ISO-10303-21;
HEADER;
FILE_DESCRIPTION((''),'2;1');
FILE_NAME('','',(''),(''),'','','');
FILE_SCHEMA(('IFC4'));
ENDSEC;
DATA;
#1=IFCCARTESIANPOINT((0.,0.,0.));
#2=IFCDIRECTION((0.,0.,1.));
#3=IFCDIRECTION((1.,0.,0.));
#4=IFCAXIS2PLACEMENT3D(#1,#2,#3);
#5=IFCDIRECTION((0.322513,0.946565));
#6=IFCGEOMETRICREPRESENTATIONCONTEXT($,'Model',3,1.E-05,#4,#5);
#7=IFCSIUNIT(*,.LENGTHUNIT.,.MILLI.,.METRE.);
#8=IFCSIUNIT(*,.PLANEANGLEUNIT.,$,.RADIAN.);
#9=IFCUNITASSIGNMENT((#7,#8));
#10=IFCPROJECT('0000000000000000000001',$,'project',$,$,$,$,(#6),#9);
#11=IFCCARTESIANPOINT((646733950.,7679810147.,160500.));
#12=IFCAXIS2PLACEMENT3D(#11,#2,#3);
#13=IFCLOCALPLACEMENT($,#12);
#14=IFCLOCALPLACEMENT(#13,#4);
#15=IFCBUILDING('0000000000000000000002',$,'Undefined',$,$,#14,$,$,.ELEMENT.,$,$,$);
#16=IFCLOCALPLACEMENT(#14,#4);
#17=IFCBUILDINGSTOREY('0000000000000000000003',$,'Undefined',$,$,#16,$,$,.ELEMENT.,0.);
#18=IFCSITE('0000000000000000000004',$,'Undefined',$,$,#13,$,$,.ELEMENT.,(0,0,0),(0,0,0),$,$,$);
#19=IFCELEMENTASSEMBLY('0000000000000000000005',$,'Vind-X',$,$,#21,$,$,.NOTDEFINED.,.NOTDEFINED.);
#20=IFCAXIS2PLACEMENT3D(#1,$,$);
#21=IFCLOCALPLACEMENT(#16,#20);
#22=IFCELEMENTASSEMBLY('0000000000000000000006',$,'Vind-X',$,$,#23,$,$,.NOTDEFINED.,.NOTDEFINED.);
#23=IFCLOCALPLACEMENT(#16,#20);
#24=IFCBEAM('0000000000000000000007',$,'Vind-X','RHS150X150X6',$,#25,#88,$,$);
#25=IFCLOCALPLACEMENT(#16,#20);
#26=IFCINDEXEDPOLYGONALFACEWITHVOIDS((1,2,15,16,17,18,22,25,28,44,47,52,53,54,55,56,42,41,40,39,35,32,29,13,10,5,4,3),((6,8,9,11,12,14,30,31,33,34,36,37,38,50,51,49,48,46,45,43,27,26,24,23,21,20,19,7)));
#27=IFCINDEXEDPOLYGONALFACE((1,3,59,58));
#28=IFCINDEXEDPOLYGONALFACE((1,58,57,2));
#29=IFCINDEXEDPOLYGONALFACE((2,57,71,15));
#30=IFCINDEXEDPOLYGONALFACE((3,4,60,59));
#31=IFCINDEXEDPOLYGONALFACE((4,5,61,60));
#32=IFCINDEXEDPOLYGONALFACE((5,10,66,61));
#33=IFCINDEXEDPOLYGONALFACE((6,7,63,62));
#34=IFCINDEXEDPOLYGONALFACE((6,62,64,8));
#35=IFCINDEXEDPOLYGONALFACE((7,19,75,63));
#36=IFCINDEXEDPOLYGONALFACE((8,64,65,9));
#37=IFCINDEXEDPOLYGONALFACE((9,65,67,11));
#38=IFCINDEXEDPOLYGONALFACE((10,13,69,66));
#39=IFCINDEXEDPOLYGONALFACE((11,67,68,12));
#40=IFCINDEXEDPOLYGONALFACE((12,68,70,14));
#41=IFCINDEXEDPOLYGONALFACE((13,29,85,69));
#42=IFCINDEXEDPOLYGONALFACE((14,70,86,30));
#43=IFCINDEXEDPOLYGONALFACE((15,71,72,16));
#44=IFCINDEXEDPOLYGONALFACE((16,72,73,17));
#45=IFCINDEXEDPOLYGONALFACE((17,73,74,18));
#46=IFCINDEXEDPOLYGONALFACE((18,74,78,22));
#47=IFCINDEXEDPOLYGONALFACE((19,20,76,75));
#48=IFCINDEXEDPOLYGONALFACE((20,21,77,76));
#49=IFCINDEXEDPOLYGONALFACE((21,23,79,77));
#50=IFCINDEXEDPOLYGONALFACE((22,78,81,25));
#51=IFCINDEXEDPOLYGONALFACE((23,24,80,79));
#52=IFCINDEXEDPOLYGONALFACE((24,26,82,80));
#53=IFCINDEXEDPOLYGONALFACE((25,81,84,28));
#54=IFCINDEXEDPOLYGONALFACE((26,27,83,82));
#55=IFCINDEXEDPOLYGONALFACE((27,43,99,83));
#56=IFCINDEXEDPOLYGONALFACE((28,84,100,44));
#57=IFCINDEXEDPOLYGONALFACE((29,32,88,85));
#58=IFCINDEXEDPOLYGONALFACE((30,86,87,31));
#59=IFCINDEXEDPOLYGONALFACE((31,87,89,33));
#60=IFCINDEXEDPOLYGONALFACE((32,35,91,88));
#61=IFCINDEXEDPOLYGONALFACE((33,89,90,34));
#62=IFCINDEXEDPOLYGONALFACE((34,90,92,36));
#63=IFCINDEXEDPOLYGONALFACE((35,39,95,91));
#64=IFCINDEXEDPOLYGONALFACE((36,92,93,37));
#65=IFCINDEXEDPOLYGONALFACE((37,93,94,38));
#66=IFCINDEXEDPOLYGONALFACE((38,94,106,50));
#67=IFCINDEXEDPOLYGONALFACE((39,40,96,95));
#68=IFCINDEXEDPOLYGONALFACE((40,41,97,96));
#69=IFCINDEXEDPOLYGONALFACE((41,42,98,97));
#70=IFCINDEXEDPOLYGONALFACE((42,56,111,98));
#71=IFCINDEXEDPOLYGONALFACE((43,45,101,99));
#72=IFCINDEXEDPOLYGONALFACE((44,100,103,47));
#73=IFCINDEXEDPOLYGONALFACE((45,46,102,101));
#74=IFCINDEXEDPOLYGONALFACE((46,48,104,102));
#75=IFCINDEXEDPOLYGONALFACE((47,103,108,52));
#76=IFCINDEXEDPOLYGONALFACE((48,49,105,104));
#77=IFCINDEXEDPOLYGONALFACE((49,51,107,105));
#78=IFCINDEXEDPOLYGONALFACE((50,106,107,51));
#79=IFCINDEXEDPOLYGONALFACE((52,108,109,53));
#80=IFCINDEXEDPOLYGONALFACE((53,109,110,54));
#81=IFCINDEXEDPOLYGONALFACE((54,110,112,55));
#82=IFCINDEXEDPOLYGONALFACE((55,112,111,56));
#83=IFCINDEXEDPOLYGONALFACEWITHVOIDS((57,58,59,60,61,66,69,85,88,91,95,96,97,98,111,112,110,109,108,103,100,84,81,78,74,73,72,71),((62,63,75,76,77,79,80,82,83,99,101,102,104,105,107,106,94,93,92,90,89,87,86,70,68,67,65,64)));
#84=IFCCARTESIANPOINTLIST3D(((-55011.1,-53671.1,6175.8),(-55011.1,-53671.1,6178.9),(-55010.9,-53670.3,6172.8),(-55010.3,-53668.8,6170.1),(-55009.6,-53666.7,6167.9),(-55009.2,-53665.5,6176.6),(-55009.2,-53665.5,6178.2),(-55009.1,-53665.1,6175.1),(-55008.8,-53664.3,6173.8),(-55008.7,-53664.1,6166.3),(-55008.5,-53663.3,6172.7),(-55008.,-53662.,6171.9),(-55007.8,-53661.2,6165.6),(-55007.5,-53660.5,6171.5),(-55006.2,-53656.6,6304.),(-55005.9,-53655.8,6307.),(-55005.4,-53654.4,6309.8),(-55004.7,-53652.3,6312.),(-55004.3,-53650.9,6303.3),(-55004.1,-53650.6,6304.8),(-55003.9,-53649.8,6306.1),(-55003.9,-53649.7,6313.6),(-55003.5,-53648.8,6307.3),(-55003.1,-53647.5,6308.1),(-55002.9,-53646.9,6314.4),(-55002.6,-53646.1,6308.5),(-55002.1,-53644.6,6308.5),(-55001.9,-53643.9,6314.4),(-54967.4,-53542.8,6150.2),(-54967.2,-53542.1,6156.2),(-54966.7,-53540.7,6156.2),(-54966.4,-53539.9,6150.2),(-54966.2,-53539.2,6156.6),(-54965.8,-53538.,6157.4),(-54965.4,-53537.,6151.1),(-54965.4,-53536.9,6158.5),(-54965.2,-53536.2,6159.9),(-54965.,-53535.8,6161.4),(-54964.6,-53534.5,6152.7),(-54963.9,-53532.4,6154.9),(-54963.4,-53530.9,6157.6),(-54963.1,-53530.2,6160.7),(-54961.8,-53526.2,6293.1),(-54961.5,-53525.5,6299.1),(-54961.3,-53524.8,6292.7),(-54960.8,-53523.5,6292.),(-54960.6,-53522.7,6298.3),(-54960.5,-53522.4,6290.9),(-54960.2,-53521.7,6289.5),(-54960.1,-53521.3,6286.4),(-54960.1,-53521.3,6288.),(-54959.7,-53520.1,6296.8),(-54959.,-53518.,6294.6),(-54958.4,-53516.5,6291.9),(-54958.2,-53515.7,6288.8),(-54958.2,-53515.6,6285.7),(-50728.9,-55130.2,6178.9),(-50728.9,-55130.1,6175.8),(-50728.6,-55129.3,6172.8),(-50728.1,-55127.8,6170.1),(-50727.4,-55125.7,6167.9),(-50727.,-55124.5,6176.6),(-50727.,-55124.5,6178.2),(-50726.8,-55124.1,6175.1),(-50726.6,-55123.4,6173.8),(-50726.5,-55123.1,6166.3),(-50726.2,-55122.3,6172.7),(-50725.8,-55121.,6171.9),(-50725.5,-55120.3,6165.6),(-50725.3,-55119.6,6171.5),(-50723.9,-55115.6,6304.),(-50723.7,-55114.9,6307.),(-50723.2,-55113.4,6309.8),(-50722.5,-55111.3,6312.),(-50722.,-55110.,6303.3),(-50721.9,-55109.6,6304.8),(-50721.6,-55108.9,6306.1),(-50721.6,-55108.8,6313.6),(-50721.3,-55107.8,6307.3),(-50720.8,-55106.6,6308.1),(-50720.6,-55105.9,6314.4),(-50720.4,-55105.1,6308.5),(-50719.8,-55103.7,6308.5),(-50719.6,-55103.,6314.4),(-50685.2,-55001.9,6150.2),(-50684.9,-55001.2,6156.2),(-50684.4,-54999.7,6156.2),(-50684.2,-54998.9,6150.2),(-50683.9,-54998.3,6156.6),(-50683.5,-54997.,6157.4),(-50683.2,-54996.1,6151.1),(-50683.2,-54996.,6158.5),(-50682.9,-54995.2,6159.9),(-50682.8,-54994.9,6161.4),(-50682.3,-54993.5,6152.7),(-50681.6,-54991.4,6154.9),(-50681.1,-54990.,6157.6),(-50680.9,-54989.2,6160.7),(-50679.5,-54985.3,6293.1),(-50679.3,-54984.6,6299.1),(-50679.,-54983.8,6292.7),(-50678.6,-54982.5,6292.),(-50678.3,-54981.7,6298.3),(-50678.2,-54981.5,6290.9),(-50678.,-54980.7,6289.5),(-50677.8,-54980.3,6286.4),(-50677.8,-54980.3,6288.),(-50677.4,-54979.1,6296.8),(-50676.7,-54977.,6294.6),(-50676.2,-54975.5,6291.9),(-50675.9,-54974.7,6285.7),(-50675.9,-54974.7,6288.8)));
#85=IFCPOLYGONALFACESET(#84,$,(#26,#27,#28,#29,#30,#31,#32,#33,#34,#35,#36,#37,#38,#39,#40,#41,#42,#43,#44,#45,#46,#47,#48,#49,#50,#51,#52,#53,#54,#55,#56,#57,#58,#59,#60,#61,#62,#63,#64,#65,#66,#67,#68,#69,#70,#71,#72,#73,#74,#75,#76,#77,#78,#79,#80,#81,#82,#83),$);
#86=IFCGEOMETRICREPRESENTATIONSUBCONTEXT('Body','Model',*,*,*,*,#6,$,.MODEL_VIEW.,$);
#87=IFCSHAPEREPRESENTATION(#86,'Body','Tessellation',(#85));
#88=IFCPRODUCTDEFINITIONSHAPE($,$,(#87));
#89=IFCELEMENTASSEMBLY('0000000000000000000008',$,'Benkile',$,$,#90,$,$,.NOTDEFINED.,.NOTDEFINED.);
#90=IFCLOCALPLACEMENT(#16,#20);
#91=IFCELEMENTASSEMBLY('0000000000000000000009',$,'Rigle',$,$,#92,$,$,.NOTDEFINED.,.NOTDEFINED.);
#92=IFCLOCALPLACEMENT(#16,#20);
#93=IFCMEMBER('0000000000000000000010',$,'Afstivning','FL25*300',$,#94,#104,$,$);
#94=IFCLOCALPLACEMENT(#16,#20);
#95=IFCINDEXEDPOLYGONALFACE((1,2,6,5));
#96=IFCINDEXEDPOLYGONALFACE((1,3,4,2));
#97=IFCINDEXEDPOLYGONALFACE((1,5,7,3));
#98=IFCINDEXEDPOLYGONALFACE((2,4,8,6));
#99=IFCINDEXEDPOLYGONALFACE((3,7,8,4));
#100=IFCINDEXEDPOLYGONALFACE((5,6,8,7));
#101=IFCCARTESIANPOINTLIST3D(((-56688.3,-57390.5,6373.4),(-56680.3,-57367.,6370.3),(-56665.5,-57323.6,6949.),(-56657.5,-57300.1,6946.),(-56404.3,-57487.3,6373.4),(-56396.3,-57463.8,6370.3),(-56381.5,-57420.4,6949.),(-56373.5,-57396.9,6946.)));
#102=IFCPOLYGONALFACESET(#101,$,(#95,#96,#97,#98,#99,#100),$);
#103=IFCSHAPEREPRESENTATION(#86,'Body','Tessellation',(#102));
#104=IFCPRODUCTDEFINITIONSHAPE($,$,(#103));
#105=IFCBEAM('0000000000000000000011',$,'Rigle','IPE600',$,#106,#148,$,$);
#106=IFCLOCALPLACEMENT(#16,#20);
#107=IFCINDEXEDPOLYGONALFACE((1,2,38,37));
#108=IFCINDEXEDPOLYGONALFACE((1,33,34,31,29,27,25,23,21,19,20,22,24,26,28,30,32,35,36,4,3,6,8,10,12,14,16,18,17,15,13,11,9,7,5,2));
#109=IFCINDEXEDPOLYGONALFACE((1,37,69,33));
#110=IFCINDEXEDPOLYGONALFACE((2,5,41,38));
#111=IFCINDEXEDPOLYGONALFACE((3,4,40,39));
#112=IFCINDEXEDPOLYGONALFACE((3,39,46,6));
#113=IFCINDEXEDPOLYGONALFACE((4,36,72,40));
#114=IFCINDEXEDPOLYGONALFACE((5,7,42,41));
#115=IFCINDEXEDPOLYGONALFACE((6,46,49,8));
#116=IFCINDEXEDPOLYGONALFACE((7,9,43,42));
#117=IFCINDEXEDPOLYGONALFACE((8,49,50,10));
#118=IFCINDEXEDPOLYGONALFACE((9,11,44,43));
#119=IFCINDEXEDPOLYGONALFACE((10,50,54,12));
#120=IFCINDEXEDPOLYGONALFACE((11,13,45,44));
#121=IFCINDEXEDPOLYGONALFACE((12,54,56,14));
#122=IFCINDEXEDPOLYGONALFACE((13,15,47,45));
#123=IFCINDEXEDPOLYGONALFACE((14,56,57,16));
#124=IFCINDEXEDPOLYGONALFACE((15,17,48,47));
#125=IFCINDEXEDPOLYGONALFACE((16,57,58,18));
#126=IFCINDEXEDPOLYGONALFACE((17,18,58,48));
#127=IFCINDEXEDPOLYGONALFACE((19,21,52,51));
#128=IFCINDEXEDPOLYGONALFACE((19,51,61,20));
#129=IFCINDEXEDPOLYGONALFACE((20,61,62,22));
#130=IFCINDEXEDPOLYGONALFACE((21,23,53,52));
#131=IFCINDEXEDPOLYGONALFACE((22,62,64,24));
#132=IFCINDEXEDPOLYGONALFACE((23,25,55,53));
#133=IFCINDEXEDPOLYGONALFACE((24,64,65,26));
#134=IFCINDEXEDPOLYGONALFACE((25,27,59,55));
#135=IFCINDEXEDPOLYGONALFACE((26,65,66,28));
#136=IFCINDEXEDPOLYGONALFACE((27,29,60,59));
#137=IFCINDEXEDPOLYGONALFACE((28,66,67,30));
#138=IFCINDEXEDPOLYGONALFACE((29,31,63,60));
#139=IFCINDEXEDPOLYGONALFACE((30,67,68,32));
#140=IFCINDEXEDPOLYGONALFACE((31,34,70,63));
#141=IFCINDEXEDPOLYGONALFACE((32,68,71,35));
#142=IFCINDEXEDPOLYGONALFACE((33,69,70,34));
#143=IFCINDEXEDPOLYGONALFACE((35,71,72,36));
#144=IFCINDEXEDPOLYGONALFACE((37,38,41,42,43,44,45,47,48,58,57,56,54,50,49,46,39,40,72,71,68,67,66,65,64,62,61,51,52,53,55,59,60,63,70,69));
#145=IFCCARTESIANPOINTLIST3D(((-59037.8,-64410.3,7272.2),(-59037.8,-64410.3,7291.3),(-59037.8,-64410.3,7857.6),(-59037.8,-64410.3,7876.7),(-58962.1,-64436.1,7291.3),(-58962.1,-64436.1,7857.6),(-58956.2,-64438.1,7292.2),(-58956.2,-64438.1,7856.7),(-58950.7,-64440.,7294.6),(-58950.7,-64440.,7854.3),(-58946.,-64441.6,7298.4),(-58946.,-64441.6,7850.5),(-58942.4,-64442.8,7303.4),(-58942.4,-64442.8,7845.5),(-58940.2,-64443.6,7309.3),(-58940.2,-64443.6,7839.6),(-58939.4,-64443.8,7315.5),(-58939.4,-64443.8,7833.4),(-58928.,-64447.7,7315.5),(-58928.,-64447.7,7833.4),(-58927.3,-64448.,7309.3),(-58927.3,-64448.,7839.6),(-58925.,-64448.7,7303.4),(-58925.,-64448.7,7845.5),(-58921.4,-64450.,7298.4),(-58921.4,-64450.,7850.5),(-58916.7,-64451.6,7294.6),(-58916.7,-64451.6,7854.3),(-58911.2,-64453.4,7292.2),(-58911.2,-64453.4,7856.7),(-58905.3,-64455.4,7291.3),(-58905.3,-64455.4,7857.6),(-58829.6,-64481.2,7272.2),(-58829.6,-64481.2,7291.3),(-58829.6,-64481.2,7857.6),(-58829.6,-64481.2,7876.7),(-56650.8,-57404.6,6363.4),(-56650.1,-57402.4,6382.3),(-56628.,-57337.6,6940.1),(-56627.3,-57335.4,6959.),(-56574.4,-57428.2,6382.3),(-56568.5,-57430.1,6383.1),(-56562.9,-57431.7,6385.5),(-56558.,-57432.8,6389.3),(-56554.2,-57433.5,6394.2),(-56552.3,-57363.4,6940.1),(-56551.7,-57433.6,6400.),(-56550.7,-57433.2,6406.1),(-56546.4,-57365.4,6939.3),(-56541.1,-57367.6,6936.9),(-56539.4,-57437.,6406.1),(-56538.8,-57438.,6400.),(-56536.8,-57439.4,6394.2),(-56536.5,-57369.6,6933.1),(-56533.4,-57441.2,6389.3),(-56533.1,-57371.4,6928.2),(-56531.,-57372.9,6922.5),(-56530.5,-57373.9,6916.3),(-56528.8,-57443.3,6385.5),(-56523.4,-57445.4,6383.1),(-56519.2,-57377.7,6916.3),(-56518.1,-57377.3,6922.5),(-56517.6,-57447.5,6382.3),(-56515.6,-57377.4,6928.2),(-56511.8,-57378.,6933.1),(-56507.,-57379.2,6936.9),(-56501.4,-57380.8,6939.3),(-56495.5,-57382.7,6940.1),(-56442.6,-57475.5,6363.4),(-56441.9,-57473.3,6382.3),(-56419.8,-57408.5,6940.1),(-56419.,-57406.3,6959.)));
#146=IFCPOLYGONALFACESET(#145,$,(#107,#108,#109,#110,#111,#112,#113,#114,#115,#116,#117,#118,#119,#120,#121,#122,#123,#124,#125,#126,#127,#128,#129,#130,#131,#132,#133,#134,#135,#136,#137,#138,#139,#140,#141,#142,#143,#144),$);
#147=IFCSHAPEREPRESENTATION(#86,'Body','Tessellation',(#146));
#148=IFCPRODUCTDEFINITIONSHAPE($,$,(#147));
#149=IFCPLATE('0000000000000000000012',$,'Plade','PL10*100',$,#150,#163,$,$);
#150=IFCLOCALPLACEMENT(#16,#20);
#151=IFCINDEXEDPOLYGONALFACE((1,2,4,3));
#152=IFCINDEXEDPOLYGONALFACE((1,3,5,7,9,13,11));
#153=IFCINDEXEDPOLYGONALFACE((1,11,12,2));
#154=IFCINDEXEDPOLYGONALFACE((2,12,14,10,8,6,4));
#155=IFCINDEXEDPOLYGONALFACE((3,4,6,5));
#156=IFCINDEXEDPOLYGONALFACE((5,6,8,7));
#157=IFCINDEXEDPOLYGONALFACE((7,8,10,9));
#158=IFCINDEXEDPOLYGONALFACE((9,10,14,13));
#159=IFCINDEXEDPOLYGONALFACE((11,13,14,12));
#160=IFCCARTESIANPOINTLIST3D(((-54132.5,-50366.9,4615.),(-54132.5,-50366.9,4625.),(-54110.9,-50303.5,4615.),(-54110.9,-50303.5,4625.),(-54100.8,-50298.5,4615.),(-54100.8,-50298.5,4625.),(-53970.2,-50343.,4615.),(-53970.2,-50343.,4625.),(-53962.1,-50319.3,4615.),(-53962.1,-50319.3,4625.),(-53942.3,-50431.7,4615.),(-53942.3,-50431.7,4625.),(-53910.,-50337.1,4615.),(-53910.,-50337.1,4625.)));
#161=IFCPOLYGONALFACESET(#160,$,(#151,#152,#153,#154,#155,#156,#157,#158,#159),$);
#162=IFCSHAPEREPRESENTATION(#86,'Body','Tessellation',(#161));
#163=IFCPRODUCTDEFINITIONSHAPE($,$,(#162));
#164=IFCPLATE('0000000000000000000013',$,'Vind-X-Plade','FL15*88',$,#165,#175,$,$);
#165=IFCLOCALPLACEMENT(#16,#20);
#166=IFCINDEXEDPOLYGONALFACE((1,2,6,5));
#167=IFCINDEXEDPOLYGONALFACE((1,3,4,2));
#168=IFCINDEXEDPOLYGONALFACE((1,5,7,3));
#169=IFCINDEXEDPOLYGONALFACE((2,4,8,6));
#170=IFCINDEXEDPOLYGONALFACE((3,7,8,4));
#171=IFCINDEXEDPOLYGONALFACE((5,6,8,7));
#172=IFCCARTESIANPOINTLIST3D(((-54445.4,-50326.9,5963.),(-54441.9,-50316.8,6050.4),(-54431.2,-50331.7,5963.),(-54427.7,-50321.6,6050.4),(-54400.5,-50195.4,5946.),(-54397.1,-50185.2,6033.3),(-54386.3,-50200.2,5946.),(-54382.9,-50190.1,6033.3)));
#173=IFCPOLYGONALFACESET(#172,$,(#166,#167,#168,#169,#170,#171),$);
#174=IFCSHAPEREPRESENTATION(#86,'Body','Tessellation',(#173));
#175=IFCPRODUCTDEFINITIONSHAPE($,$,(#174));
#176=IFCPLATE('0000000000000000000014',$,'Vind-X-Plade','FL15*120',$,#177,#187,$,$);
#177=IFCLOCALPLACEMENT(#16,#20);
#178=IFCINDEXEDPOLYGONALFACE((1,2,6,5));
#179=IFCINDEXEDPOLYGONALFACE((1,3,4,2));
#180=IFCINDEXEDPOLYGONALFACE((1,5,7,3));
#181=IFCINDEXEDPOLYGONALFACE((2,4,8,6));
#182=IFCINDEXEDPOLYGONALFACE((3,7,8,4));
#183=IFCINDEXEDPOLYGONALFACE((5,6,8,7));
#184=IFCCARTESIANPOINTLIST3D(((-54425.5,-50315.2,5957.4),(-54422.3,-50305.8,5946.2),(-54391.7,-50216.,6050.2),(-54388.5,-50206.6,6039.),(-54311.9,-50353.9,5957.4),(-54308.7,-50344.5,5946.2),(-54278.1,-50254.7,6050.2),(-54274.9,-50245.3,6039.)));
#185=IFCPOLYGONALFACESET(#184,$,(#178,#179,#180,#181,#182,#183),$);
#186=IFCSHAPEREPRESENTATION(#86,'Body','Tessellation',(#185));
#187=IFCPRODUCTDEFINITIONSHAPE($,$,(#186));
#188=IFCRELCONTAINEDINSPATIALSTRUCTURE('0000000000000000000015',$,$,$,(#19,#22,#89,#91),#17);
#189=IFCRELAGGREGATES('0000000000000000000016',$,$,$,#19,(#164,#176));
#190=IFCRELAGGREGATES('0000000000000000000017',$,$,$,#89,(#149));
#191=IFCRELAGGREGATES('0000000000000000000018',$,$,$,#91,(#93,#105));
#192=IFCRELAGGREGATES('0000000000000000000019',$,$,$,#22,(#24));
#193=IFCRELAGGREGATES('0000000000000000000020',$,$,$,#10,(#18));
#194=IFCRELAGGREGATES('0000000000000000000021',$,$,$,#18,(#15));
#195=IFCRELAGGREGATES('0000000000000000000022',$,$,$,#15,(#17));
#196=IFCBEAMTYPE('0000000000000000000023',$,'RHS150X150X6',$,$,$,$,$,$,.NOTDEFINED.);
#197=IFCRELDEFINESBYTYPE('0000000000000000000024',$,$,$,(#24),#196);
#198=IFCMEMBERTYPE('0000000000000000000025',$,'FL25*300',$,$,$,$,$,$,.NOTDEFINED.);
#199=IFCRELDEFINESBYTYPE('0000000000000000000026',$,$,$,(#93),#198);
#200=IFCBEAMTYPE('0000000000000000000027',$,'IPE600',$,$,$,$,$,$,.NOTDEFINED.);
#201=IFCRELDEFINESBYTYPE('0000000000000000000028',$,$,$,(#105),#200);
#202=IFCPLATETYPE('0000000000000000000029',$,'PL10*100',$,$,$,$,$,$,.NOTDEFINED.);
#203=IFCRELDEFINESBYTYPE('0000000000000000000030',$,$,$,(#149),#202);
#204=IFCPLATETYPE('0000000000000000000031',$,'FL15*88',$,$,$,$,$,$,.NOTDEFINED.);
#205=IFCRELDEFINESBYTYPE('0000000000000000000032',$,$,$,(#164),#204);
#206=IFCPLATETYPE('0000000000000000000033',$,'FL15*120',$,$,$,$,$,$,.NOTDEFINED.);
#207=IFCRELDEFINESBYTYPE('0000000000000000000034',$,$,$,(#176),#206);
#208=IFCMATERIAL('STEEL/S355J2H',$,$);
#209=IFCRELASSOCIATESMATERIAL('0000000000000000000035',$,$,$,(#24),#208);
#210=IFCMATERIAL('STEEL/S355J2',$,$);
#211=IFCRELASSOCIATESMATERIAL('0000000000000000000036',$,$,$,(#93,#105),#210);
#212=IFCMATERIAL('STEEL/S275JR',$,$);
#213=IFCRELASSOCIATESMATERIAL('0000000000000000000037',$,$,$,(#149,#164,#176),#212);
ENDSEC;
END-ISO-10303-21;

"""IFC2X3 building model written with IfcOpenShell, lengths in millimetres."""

from ifc_helpers import new_model, si_unit, direction, frame, origin_with_axes, origin_2d_with_axis, place, context, subcontext, project, spatial, polyline, rectangle, hollow_rectangle, i_section, outline, extrude, boolean, clip, halfspace, material, type_object, element, aggregate, save


model = new_model("IFC2X3")

# Units and contexts
model_context = context("Model", 3, precision=1e-05, world=origin_with_axes(), true_north=direction((0.322513, 0.946565)))
body_context = subcontext(model_context, "Body", "Model", "MODEL_VIEW")
ifc_project = project(units=[si_unit("LENGTHUNIT", "METRE", prefix="MILLI"), si_unit("PLANEANGLEUNIT", "RADIAN")], contexts=[model_context])

# Site, building, storey
site_placement = place(None, frame((646733950.0, 7679810147.0, 160500.0), z_axis=(0.0, 0.0, 1.0), x_axis=(1.0, 0.0, 0.0)))
site = spatial("IfcSite", under=ifc_project, at=site_placement, Name="Undefined", CompositionType="ELEMENT", RefLatitude=(0, 0, 0), RefLongitude=(0, 0, 0))
building_placement = place(site_placement, origin_with_axes())
building = spatial("IfcBuilding", under=site, at=building_placement, Name="Undefined", CompositionType="ELEMENT")
storey_placement = place(building_placement, origin_with_axes())
storey = spatial("IfcBuildingStorey", under=building, at=storey_placement, Name="Undefined", CompositionType="ELEMENT", Elevation=0.0)

# Element assemblies, beam
assembly_1_placement = place(storey_placement, origin_with_axes())
assembly_1 = element("IfcElementAssembly", 1, at=assembly_1_placement, inside=storey, Name="Vind-X", AssemblyPlace="NOTDEFINED", PredefinedType="NOTDEFINED")
ifc_material_1 = material(Name="STEEL/S355J2H")
beam_type_1 = type_object("IfcBeamType", Name="RHS150X150X6", PredefinedType="NOTDEFINED")
assembly_2_placement = place(storey_placement, origin_with_axes())
assembly_2 = element("IfcElementAssembly", 2, at=assembly_2_placement, inside=storey, Name="Vind-X", AssemblyPlace="NOTDEFINED", PredefinedType="NOTDEFINED")
beam_1_placement = place(assembly_2_placement, frame((-55121.9, -53546.6, 6232.3), z_axis=(-0.039304, -0.115357, -0.992546), x_axis=(0.946565, -0.322513, 0.0)))
beam_1 = element("IfcBeam", 3, at=beam_1_placement, type_object=beam_type_1, material=ifc_material_1, Name="Vind-X", Description="RHS150X150X6", context=body_context, shape_type="Clipping", body=[
    clip(clip(extrude(hollow_rectangle(XDim=150.0, YDim=150.0, WallThickness=6.0, InnerFilletRadius=6.0, OuterFilletRadius=12.0, at=origin_2d_with_axis()), frame((4814.0, 0.0, 0.0), z_axis=(-1.0, 0.0, 0.0), x_axis=(0.0, -1.0, 0.0)), (0.0, 0.0, 1.0), 4814.0), halfspace(frame((4669.0, 0.0, 0.0), z_axis=(-1.0, 0.0, 0.0), x_axis=(0.0, 1.0, 0.0)), True)), halfspace(frame((145.0, 0.0, 0.0), z_axis=(1.0, 0.0, 0.0), x_axis=(0.0, -1.0, 0.0)), True)),
])

# Element assembly
assembly_3_placement = place(storey_placement, origin_with_axes())
assembly_3 = element("IfcElementAssembly", 4, at=assembly_3_placement, inside=storey, Name="Benkile", AssemblyPlace="NOTDEFINED", PredefinedType="NOTDEFINED")
ifc_material_2 = material(Name="STEEL/S355J2")
member_type = type_object("IfcMemberType", Name="FL25*300", PredefinedType="NOTDEFINED")

# Element assembly, member, beam
assembly_4_placement = place(storey_placement, origin_with_axes())
assembly_4 = element("IfcElementAssembly", 5, at=assembly_4_placement, inside=storey, Name="Rigle", AssemblyPlace="NOTDEFINED", PredefinedType="NOTDEFINED")
member_1_placement = place(assembly_4_placement, frame((-56519.5, -57360.2, 6947.5), z_axis=(-0.946565, 0.322513, 0.0), x_axis=(-0.039304, -0.115357, -0.992546)))
member_1 = element("IfcMember", 6, at=member_1_placement, type_object=member_type, material=ifc_material_2, Name="Afstivning", Description="FL25*300", context=body_context, shape_type="SweptSolid", body=[
    extrude(rectangle(XDim=25.0, YDim=300.0, at=origin_2d_with_axis()), frame((580.0, 0.0, 0.0), z_axis=(-1.0, 0.0, 0.0), x_axis=(0.0, -1.0, 0.0)), (0.0, 0.0, 1.0), 580.0),
])
beam_type_2 = type_object("IfcBeamType", Name="IPE600", PredefinedType="NOTDEFINED")
beam_2_placement = place(assembly_4_placement, frame((-56530.9, -57393.7, 6659.7), z_axis=(0.039304, 0.115357, 0.992546), x_axis=(-0.320109, -0.93951, 0.121869)))
beam_2 = element("IfcBeam", 7, at=beam_2_placement, type_object=beam_type_2, material=ifc_material_2, Name="Rigle", Description="IPE600", context=body_context, shape_type="Clipping", body=[
    clip(clip(extrude(i_section(OverallWidth=220.0, OverallDepth=600.0, WebThickness=12.0, FlangeThickness=19.0, FilletRadius=24.0, at=origin_2d_with_axis()), frame((7751.3, 0.0, 0.0), z_axis=(-1.0, 0.0, 0.0), x_axis=(0.0, -1.0, 0.0)), (0.0, 0.0, 1.0), 7983.9), halfspace(frame((7543.3, 0.0, 303.0), z_axis=(0.992546, 0.0, -0.121869), x_axis=(0.0, 1.0, 0.0)), False)), halfspace(frame((12.5, 0.0, 0.0), z_axis=(-1.0, 0.0, 0.0), x_axis=(0.0, 1.0, 0.0)), False)),
])

# Plates
ifc_material_3 = material(Name="STEEL/S275JR")
plate_type_1 = type_object("IfcPlateType", Name="PL10*100", PredefinedType="NOTDEFINED")
plate_1_placement = place(assembly_3_placement, frame((-54132.5, -50366.9, 4620.0), z_axis=(0.0, 0.0, 1.0), x_axis=(0.946565, -0.322513, 0.0)))
plate_1 = element("IfcPlate", 8, at=plate_1_placement, type_object=plate_type_1, material=ifc_material_3, Name="Plade", Description="PL10*100", context=body_context, shape_type="CSG", body=[
    boolean("DIFFERENCE", extrude(outline(polyline([(0.0, 0.0), (201.0, 0.0), (201.0, 100.0), (146.0, 100.0), (146.0, 75.0), (0.0, 75.0), (0.0, 0.0)])), frame((0.0, 0.0, -5.0), z_axis=(0.0, 0.0, 1.0), x_axis=(1.0, 0.0, 0.0)), (0.0, 0.0, 1.0), 10.0), extrude(outline(polyline([(0.0, 0.0), (8.0, 0.0), (0.0, 8.0), (0.0, 0.0)])), frame((0.0, 75.0, 7.5), z_axis=(0.0, 0.0, -1.0), x_axis=(1.0, 0.0, 0.0)), (0.0, 0.0, 1.0), 15.0)),
])
plate_type_2 = type_object("IfcPlateType", Name="FL15*88", PredefinedType="NOTDEFINED")
plate_2_placement = place(assembly_1_placement, frame((-54438.3, -50329.3, 5963.0), z_axis=(0.946565, -0.322513, 0.0), x_axis=(0.320109, 0.93951, -0.121869)))
plate_2 = element("IfcPlate", 9, at=plate_2_placement, type_object=plate_type_2, material=ifc_material_3, Name="Vind-X-Plade", Description="FL15*88", context=body_context, shape_type="SweptSolid", body=[
    extrude(outline(polyline([(0.0, 0.0), (140.0, 0.0), (140.0, 88.0), (0.0, 88.0), (0.0, 0.0)])), frame((0.0, 0.0, -7.5), z_axis=(0.0, 0.0, 1.0), x_axis=(1.0, 0.0, 0.0)), (0.0, 0.0, 1.0), 15.0),
])
plate_type_3 = type_object("IfcPlateType", Name="FL15*120", PredefinedType="NOTDEFINED")
plate_3_placement = place(assembly_1_placement, frame((-54293.4, -50299.6, 5998.2), z_axis=(0.213703, 0.627213, -0.748956), x_axis=(-0.946565, 0.322513, 0.0)))
plate_3 = element("IfcPlate", 10, at=plate_3_placement, type_object=plate_type_3, material=ifc_material_3, Name="Vind-X-Plade", Description="FL15*120", context=body_context, shape_type="SweptSolid", body=[
    extrude(outline(polyline([(0.0, -70.0), (0.0, 70.0), (120.0, 70.0), (120.0, -70.0), (0.0, -70.0)])), frame((0.0, 0.0, -7.5), z_axis=(0.0, 0.0, 1.0), x_axis=(1.0, 0.0, 0.0)), (0.0, 0.0, 1.0), 15.0),
])
aggregate(assembly_1, [plate_2, plate_3])

aggregate(assembly_3, [plate_1])
aggregate(assembly_4, [member_1, beam_2])
aggregate(assembly_2, [beam_1])

save(model, "model.ifc")
